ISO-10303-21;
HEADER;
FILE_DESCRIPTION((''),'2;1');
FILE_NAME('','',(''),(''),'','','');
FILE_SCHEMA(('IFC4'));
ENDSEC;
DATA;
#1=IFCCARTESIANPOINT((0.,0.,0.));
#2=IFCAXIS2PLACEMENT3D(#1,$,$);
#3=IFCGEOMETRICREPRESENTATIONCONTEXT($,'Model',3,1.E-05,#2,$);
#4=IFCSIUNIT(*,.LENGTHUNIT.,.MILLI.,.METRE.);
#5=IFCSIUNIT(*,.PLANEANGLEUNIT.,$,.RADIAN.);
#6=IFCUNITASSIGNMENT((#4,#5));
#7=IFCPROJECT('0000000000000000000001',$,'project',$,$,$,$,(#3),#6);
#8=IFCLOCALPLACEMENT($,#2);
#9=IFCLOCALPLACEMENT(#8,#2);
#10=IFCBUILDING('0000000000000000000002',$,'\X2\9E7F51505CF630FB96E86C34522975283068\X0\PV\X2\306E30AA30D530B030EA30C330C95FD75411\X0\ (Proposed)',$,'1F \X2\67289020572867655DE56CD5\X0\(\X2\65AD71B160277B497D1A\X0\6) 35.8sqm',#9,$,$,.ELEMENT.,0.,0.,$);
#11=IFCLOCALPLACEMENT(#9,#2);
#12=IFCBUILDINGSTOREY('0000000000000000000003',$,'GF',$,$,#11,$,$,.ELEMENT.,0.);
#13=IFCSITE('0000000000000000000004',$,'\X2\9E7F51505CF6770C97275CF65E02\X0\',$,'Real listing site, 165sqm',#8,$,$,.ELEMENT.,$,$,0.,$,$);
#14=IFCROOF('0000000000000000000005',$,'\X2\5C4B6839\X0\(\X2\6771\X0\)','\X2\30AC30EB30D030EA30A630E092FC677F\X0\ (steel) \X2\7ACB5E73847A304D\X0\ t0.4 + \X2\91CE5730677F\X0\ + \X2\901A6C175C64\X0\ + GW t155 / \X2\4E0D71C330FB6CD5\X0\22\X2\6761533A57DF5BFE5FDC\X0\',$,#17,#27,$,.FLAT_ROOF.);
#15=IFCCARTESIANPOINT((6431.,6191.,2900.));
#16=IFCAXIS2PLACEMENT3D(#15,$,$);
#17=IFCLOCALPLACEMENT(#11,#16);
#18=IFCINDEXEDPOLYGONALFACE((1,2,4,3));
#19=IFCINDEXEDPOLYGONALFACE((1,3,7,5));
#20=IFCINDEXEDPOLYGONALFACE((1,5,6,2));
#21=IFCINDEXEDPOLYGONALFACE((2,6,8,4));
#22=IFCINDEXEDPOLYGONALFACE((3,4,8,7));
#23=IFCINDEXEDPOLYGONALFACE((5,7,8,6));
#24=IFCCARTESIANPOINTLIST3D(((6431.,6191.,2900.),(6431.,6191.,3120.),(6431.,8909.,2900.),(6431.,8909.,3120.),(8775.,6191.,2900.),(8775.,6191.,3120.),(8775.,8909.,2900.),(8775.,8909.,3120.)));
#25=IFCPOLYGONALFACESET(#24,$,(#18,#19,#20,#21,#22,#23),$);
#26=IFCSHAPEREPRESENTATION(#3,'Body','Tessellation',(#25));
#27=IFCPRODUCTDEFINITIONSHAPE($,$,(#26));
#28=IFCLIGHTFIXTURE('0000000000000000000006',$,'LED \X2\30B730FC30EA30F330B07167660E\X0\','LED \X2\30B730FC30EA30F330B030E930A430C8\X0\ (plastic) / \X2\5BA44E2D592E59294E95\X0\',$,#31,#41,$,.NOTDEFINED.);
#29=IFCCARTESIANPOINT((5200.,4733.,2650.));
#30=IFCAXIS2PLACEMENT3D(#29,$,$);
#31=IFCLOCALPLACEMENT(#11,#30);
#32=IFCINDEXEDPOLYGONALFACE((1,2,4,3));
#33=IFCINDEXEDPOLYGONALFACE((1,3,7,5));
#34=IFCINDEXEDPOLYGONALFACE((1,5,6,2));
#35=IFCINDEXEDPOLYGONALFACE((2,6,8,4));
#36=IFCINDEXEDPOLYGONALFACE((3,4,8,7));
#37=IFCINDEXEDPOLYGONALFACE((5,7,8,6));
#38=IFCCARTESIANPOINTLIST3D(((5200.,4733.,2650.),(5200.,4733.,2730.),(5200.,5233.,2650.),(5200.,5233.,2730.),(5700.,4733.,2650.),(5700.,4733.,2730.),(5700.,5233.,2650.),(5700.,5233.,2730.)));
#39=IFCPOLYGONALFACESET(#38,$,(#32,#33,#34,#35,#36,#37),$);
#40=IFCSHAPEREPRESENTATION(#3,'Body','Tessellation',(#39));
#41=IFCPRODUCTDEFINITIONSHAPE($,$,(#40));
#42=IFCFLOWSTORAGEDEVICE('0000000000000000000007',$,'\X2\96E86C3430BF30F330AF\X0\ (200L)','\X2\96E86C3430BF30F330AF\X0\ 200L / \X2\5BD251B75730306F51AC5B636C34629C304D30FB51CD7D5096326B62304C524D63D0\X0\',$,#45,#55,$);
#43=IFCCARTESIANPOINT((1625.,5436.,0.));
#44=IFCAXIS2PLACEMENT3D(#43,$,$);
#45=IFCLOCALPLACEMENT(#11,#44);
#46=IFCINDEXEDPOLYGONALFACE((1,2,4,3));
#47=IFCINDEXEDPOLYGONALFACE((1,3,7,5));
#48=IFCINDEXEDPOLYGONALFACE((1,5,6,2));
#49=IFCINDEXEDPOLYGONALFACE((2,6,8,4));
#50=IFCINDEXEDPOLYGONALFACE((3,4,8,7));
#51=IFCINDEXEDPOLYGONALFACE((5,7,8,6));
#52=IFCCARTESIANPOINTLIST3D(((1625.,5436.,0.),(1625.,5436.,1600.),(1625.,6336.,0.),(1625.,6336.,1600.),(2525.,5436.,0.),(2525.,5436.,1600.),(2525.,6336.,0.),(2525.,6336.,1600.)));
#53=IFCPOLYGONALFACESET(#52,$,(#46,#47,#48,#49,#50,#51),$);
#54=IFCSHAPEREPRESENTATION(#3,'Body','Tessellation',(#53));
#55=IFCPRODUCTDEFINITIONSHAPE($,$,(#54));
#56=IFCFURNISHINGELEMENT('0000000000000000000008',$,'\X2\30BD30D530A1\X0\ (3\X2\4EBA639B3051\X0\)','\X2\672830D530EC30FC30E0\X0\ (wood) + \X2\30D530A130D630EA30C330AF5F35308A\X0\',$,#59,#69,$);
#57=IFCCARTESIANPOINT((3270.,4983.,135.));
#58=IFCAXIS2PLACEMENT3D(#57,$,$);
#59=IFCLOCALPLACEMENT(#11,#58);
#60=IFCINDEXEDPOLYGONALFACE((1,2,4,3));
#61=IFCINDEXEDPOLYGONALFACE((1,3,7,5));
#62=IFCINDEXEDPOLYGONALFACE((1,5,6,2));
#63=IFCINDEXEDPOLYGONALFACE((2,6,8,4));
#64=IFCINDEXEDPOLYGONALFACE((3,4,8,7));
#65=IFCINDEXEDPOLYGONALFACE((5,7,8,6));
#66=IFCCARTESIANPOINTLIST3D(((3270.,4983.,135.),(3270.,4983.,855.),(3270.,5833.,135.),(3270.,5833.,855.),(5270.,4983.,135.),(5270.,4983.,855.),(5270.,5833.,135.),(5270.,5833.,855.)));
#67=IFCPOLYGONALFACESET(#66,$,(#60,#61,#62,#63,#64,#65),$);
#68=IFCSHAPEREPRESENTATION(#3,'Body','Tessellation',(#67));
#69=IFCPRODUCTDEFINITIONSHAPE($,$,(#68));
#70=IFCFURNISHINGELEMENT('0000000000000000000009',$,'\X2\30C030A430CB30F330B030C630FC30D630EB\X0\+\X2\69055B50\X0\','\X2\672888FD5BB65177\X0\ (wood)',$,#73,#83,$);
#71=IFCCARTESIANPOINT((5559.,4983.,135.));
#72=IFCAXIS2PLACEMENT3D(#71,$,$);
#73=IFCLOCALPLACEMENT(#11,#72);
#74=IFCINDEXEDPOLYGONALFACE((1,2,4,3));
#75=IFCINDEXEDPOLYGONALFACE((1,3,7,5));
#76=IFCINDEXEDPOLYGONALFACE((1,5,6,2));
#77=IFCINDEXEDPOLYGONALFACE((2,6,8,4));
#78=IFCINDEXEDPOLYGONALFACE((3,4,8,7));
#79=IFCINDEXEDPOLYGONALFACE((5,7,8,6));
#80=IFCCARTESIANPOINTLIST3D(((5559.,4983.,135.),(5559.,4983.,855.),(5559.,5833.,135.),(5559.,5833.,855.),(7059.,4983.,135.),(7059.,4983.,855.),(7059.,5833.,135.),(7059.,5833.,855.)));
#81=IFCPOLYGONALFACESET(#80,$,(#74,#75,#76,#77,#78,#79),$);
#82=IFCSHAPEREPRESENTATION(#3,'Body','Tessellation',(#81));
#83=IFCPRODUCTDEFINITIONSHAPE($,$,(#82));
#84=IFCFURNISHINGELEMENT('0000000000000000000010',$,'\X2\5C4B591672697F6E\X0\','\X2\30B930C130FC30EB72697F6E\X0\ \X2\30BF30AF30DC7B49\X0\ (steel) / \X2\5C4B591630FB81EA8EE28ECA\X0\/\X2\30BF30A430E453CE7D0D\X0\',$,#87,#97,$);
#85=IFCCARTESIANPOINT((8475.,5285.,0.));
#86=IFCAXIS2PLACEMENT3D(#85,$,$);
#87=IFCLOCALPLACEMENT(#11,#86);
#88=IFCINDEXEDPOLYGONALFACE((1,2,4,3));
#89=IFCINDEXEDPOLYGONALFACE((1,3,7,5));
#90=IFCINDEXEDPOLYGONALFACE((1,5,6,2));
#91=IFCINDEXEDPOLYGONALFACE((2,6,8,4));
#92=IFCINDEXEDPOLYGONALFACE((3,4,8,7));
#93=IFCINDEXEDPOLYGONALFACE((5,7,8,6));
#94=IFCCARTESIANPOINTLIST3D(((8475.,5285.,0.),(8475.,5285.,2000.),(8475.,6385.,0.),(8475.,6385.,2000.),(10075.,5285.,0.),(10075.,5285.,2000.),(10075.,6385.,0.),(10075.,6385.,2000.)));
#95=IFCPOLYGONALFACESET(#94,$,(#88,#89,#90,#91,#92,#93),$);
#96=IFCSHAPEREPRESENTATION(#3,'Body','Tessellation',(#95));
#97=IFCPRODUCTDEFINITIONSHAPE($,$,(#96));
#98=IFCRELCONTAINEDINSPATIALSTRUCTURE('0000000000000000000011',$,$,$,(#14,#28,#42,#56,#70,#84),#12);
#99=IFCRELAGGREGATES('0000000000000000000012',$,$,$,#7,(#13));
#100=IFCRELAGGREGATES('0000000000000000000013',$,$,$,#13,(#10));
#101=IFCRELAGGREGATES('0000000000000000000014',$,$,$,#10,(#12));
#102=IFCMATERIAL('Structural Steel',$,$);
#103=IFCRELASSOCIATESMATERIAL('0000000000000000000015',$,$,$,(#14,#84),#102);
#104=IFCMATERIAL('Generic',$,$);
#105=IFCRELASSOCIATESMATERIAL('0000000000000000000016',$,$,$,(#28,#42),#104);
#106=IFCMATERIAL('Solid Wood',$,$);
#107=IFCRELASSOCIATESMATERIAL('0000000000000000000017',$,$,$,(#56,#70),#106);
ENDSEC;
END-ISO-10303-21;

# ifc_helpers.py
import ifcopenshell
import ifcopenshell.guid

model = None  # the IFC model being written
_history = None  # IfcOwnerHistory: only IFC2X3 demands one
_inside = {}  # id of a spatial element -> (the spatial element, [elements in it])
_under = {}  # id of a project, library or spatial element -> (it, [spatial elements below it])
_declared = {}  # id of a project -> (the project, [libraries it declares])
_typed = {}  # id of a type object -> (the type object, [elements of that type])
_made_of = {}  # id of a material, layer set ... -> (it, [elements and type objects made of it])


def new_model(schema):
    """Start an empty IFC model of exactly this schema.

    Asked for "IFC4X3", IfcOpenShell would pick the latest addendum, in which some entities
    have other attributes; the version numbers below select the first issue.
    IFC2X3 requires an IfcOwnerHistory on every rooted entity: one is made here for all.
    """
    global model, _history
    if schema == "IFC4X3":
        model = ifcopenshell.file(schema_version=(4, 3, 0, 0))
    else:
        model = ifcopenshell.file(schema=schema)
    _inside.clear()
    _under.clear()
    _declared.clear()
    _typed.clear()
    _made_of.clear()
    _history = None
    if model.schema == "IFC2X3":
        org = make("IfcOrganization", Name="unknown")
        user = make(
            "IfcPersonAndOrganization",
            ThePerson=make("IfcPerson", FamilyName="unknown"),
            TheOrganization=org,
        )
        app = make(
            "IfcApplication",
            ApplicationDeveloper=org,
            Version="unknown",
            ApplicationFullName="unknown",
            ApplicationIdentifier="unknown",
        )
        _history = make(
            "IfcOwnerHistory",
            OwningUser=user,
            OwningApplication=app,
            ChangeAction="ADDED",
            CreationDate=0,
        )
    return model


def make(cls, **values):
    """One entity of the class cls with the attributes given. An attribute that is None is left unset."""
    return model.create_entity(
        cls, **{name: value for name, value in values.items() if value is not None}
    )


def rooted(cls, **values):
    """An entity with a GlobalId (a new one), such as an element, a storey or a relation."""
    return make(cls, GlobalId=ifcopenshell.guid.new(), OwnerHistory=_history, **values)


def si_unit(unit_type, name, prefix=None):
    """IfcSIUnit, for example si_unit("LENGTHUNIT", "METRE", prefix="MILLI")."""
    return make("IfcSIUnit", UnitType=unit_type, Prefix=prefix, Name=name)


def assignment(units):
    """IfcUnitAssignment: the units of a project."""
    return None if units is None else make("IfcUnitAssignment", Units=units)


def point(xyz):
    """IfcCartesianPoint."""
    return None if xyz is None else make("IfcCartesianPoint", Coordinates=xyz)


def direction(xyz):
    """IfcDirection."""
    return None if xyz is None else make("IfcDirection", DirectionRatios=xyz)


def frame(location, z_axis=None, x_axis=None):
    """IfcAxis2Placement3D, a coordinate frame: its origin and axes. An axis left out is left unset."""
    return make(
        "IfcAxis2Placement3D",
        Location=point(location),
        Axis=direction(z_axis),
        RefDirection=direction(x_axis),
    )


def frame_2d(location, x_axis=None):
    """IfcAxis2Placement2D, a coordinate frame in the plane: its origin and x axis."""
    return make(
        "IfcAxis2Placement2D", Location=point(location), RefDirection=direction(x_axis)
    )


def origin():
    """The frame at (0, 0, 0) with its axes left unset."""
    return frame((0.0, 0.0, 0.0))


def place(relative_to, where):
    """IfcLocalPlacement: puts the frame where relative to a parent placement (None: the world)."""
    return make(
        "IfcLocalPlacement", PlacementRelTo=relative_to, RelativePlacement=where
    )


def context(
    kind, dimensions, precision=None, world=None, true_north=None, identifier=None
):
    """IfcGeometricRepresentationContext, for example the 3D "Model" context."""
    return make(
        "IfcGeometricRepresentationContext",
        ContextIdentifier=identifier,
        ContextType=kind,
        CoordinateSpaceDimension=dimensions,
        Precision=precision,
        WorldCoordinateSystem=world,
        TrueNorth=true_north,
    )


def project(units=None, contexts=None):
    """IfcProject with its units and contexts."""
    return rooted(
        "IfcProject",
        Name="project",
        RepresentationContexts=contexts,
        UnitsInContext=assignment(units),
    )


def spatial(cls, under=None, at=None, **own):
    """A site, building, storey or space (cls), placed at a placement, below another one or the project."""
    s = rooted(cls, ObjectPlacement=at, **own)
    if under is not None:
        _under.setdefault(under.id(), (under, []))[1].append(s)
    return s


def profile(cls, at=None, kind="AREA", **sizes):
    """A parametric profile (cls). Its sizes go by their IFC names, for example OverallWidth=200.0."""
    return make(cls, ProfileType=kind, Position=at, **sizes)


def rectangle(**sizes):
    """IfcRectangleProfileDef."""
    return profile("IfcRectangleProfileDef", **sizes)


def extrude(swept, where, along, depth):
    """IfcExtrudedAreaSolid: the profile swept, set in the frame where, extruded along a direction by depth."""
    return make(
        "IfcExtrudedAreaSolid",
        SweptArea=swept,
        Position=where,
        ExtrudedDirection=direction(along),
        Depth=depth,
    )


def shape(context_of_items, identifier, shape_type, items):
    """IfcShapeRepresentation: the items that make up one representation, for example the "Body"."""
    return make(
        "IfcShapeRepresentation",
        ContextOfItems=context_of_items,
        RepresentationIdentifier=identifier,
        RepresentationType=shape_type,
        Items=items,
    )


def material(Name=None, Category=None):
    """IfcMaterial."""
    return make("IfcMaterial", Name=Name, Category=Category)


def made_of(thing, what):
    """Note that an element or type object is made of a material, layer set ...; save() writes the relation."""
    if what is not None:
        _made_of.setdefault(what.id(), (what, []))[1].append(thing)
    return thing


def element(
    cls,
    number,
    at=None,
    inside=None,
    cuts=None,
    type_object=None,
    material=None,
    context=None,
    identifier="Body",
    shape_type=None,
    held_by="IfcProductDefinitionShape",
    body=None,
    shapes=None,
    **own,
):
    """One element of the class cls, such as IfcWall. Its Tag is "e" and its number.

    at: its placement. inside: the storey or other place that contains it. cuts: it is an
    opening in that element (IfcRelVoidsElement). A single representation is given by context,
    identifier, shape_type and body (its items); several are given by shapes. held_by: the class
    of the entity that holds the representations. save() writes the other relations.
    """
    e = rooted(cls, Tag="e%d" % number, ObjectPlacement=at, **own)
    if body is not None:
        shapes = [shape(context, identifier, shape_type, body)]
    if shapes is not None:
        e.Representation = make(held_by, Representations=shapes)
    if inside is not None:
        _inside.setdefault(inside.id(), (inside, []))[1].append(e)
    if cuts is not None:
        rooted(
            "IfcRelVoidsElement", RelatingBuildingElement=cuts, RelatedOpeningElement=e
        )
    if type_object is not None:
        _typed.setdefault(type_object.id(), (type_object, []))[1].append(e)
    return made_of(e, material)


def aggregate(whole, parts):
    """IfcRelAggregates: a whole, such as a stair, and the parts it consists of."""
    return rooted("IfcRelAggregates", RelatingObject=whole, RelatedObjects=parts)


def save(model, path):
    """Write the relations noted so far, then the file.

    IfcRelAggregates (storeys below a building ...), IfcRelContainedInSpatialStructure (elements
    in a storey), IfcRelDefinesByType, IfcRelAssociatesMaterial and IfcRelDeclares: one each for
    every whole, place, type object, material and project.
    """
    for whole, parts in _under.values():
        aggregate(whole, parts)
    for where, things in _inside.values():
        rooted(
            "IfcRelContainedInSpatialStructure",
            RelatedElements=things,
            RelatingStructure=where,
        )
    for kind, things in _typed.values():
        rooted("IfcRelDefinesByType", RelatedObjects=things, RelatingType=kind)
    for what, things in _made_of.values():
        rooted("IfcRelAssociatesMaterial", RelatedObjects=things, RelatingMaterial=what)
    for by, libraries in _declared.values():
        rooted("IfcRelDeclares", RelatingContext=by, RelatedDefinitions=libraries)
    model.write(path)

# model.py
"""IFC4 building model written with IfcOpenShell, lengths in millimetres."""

from ifc_helpers import new_model, si_unit, frame, frame_2d, origin, place, context, project, spatial, rectangle, extrude, material, element, save


model = new_model("IFC4")

# Units and contexts
model_context = context("Model", 3, precision=1e-05, world=origin())
ifc_project = project(units=[si_unit("LENGTHUNIT", "METRE", prefix="MILLI"), si_unit("PLANEANGLEUNIT", "RADIAN")], contexts=[model_context])

# Site, building, storey
site_placement = place(None, origin())
site = spatial("IfcSite", under=ifc_project, at=site_placement, Name="鹿児島県霧島市", ObjectType="Real listing site, 165sqm", CompositionType="ELEMENT", RefElevation=0.0)
building_placement = place(site_placement, origin())
building = spatial("IfcBuilding", under=site, at=building_placement, Name="鹿児島・雨水利用とPVのオフグリッド志向 (Proposed)", ObjectType="1F 木造在来工法(断熱性等級6) 35.8sqm", CompositionType="ELEMENT", ElevationOfRefHeight=0.0, ElevationOfTerrain=0.0)
storey_placement = place(building_placement, origin())
storey = spatial("IfcBuildingStorey", under=building, at=storey_placement, Name="GF", CompositionType="ELEMENT", Elevation=0.0)

# Shared definitions
ifc_material_1 = material(Name="Solid Wood")

# Roof
ifc_material_2 = material(Name="Structural Steel")
roof_1_placement = place(storey_placement, frame((6431.0, 6191.0, 2900.0)))
element("IfcRoof", 1, at=roof_1_placement, inside=storey, material=ifc_material_2, Name="屋根(東)", Description="ガルバリウム鋼板 (steel) 立平葺き t0.4 + 野地板 + 通気層 + GW t155 / 不燃・法22条区域対応", PredefinedType="FLAT_ROOF", context=model_context, shape_type="SweptSolid", body=[
    extrude(rectangle(XDim=2344.0, YDim=2718.0, at=frame_2d((1172.0, 1359.0))), frame((6431.0, 6191.0, 2900.0)), (0.0, 0.0, 1.0), 220.0),
])

# Light fixture
ifc_material_3 = material(Name="Generic")
light_fixture_placement = place(storey_placement, frame((5200.0, 4733.0, 2650.0)))
element("IfcLightFixture", 2, at=light_fixture_placement, inside=storey, material=ifc_material_3, Name="LED シーリング照明", Description="LED シーリングライト (plastic) / 室中央天井", PredefinedType="NOTDEFINED", context=model_context, shape_type="SweptSolid", body=[
    extrude(rectangle(XDim=500.0, YDim=500.0, at=frame_2d((250.0, 250.0))), frame((5200.0, 4733.0, 2650.0)), (0.0, 0.0, 1.0), 80.0),
])

# Flow storage device
flow_storage_device_placement = place(storey_placement, frame((1625.0, 5436.0, 0.0)))
element("IfcFlowStorageDevice", 3, at=flow_storage_device_placement, inside=storey, material=ifc_material_3, Name="雨水タンク (200L)", Description="雨水タンク 200L / 寒冷地は冬季水抜き・凍結防止が前提", context=model_context, shape_type="SweptSolid", body=[
    extrude(rectangle(XDim=900.0, YDim=900.0, at=frame_2d((450.0, 450.0))), frame((1625.0, 5436.0, 0.0)), (0.0, 0.0, 1.0), 1600.0),
])

# Furnishing elements
furnishing_1_placement = place(storey_placement, frame((3270.0, 4983.0, 135.0)))
element("IfcFurnishingElement", 4, at=furnishing_1_placement, inside=storey, material=ifc_material_1, Name="ソファ (3人掛け)", Description="木フレーム (wood) + ファブリック張り", context=model_context, shape_type="SweptSolid", body=[
    extrude(rectangle(XDim=2000.0, YDim=850.0, at=frame_2d((1000.0, 425.0))), frame((3270.0, 4983.0, 135.0)), (0.0, 0.0, 1.0), 720.0),
])
furnishing_2_placement = place(storey_placement, frame((5559.0, 4983.0, 135.0)))
element("IfcFurnishingElement", 5, at=furnishing_2_placement, inside=storey, material=ifc_material_1, Name="ダイニングテーブル+椅子", Description="木製家具 (wood)", context=model_context, shape_type="SweptSolid", body=[
    extrude(rectangle(XDim=1500.0, YDim=850.0, at=frame_2d((750.0, 425.0))), frame((5559.0, 4983.0, 135.0)), (0.0, 0.0, 1.0), 720.0),
])
furnishing_3_placement = place(storey_placement, frame((8475.0, 5285.0, 0.0)))
element("IfcFurnishingElement", 6, at=furnishing_3_placement, inside=storey, material=ifc_material_2, Name="屋外物置", Description="スチール物置 タクボ等 (steel) / 屋外・自転車/タイヤ収納", context=model_context, shape_type="SweptSolid", body=[
    extrude(rectangle(XDim=1600.0, YDim=1100.0, at=frame_2d((800.0, 550.0))), frame((8475.0, 5285.0, 0.0)), (0.0, 0.0, 1.0), 2000.0),
])

save(model, "model.ifc")
